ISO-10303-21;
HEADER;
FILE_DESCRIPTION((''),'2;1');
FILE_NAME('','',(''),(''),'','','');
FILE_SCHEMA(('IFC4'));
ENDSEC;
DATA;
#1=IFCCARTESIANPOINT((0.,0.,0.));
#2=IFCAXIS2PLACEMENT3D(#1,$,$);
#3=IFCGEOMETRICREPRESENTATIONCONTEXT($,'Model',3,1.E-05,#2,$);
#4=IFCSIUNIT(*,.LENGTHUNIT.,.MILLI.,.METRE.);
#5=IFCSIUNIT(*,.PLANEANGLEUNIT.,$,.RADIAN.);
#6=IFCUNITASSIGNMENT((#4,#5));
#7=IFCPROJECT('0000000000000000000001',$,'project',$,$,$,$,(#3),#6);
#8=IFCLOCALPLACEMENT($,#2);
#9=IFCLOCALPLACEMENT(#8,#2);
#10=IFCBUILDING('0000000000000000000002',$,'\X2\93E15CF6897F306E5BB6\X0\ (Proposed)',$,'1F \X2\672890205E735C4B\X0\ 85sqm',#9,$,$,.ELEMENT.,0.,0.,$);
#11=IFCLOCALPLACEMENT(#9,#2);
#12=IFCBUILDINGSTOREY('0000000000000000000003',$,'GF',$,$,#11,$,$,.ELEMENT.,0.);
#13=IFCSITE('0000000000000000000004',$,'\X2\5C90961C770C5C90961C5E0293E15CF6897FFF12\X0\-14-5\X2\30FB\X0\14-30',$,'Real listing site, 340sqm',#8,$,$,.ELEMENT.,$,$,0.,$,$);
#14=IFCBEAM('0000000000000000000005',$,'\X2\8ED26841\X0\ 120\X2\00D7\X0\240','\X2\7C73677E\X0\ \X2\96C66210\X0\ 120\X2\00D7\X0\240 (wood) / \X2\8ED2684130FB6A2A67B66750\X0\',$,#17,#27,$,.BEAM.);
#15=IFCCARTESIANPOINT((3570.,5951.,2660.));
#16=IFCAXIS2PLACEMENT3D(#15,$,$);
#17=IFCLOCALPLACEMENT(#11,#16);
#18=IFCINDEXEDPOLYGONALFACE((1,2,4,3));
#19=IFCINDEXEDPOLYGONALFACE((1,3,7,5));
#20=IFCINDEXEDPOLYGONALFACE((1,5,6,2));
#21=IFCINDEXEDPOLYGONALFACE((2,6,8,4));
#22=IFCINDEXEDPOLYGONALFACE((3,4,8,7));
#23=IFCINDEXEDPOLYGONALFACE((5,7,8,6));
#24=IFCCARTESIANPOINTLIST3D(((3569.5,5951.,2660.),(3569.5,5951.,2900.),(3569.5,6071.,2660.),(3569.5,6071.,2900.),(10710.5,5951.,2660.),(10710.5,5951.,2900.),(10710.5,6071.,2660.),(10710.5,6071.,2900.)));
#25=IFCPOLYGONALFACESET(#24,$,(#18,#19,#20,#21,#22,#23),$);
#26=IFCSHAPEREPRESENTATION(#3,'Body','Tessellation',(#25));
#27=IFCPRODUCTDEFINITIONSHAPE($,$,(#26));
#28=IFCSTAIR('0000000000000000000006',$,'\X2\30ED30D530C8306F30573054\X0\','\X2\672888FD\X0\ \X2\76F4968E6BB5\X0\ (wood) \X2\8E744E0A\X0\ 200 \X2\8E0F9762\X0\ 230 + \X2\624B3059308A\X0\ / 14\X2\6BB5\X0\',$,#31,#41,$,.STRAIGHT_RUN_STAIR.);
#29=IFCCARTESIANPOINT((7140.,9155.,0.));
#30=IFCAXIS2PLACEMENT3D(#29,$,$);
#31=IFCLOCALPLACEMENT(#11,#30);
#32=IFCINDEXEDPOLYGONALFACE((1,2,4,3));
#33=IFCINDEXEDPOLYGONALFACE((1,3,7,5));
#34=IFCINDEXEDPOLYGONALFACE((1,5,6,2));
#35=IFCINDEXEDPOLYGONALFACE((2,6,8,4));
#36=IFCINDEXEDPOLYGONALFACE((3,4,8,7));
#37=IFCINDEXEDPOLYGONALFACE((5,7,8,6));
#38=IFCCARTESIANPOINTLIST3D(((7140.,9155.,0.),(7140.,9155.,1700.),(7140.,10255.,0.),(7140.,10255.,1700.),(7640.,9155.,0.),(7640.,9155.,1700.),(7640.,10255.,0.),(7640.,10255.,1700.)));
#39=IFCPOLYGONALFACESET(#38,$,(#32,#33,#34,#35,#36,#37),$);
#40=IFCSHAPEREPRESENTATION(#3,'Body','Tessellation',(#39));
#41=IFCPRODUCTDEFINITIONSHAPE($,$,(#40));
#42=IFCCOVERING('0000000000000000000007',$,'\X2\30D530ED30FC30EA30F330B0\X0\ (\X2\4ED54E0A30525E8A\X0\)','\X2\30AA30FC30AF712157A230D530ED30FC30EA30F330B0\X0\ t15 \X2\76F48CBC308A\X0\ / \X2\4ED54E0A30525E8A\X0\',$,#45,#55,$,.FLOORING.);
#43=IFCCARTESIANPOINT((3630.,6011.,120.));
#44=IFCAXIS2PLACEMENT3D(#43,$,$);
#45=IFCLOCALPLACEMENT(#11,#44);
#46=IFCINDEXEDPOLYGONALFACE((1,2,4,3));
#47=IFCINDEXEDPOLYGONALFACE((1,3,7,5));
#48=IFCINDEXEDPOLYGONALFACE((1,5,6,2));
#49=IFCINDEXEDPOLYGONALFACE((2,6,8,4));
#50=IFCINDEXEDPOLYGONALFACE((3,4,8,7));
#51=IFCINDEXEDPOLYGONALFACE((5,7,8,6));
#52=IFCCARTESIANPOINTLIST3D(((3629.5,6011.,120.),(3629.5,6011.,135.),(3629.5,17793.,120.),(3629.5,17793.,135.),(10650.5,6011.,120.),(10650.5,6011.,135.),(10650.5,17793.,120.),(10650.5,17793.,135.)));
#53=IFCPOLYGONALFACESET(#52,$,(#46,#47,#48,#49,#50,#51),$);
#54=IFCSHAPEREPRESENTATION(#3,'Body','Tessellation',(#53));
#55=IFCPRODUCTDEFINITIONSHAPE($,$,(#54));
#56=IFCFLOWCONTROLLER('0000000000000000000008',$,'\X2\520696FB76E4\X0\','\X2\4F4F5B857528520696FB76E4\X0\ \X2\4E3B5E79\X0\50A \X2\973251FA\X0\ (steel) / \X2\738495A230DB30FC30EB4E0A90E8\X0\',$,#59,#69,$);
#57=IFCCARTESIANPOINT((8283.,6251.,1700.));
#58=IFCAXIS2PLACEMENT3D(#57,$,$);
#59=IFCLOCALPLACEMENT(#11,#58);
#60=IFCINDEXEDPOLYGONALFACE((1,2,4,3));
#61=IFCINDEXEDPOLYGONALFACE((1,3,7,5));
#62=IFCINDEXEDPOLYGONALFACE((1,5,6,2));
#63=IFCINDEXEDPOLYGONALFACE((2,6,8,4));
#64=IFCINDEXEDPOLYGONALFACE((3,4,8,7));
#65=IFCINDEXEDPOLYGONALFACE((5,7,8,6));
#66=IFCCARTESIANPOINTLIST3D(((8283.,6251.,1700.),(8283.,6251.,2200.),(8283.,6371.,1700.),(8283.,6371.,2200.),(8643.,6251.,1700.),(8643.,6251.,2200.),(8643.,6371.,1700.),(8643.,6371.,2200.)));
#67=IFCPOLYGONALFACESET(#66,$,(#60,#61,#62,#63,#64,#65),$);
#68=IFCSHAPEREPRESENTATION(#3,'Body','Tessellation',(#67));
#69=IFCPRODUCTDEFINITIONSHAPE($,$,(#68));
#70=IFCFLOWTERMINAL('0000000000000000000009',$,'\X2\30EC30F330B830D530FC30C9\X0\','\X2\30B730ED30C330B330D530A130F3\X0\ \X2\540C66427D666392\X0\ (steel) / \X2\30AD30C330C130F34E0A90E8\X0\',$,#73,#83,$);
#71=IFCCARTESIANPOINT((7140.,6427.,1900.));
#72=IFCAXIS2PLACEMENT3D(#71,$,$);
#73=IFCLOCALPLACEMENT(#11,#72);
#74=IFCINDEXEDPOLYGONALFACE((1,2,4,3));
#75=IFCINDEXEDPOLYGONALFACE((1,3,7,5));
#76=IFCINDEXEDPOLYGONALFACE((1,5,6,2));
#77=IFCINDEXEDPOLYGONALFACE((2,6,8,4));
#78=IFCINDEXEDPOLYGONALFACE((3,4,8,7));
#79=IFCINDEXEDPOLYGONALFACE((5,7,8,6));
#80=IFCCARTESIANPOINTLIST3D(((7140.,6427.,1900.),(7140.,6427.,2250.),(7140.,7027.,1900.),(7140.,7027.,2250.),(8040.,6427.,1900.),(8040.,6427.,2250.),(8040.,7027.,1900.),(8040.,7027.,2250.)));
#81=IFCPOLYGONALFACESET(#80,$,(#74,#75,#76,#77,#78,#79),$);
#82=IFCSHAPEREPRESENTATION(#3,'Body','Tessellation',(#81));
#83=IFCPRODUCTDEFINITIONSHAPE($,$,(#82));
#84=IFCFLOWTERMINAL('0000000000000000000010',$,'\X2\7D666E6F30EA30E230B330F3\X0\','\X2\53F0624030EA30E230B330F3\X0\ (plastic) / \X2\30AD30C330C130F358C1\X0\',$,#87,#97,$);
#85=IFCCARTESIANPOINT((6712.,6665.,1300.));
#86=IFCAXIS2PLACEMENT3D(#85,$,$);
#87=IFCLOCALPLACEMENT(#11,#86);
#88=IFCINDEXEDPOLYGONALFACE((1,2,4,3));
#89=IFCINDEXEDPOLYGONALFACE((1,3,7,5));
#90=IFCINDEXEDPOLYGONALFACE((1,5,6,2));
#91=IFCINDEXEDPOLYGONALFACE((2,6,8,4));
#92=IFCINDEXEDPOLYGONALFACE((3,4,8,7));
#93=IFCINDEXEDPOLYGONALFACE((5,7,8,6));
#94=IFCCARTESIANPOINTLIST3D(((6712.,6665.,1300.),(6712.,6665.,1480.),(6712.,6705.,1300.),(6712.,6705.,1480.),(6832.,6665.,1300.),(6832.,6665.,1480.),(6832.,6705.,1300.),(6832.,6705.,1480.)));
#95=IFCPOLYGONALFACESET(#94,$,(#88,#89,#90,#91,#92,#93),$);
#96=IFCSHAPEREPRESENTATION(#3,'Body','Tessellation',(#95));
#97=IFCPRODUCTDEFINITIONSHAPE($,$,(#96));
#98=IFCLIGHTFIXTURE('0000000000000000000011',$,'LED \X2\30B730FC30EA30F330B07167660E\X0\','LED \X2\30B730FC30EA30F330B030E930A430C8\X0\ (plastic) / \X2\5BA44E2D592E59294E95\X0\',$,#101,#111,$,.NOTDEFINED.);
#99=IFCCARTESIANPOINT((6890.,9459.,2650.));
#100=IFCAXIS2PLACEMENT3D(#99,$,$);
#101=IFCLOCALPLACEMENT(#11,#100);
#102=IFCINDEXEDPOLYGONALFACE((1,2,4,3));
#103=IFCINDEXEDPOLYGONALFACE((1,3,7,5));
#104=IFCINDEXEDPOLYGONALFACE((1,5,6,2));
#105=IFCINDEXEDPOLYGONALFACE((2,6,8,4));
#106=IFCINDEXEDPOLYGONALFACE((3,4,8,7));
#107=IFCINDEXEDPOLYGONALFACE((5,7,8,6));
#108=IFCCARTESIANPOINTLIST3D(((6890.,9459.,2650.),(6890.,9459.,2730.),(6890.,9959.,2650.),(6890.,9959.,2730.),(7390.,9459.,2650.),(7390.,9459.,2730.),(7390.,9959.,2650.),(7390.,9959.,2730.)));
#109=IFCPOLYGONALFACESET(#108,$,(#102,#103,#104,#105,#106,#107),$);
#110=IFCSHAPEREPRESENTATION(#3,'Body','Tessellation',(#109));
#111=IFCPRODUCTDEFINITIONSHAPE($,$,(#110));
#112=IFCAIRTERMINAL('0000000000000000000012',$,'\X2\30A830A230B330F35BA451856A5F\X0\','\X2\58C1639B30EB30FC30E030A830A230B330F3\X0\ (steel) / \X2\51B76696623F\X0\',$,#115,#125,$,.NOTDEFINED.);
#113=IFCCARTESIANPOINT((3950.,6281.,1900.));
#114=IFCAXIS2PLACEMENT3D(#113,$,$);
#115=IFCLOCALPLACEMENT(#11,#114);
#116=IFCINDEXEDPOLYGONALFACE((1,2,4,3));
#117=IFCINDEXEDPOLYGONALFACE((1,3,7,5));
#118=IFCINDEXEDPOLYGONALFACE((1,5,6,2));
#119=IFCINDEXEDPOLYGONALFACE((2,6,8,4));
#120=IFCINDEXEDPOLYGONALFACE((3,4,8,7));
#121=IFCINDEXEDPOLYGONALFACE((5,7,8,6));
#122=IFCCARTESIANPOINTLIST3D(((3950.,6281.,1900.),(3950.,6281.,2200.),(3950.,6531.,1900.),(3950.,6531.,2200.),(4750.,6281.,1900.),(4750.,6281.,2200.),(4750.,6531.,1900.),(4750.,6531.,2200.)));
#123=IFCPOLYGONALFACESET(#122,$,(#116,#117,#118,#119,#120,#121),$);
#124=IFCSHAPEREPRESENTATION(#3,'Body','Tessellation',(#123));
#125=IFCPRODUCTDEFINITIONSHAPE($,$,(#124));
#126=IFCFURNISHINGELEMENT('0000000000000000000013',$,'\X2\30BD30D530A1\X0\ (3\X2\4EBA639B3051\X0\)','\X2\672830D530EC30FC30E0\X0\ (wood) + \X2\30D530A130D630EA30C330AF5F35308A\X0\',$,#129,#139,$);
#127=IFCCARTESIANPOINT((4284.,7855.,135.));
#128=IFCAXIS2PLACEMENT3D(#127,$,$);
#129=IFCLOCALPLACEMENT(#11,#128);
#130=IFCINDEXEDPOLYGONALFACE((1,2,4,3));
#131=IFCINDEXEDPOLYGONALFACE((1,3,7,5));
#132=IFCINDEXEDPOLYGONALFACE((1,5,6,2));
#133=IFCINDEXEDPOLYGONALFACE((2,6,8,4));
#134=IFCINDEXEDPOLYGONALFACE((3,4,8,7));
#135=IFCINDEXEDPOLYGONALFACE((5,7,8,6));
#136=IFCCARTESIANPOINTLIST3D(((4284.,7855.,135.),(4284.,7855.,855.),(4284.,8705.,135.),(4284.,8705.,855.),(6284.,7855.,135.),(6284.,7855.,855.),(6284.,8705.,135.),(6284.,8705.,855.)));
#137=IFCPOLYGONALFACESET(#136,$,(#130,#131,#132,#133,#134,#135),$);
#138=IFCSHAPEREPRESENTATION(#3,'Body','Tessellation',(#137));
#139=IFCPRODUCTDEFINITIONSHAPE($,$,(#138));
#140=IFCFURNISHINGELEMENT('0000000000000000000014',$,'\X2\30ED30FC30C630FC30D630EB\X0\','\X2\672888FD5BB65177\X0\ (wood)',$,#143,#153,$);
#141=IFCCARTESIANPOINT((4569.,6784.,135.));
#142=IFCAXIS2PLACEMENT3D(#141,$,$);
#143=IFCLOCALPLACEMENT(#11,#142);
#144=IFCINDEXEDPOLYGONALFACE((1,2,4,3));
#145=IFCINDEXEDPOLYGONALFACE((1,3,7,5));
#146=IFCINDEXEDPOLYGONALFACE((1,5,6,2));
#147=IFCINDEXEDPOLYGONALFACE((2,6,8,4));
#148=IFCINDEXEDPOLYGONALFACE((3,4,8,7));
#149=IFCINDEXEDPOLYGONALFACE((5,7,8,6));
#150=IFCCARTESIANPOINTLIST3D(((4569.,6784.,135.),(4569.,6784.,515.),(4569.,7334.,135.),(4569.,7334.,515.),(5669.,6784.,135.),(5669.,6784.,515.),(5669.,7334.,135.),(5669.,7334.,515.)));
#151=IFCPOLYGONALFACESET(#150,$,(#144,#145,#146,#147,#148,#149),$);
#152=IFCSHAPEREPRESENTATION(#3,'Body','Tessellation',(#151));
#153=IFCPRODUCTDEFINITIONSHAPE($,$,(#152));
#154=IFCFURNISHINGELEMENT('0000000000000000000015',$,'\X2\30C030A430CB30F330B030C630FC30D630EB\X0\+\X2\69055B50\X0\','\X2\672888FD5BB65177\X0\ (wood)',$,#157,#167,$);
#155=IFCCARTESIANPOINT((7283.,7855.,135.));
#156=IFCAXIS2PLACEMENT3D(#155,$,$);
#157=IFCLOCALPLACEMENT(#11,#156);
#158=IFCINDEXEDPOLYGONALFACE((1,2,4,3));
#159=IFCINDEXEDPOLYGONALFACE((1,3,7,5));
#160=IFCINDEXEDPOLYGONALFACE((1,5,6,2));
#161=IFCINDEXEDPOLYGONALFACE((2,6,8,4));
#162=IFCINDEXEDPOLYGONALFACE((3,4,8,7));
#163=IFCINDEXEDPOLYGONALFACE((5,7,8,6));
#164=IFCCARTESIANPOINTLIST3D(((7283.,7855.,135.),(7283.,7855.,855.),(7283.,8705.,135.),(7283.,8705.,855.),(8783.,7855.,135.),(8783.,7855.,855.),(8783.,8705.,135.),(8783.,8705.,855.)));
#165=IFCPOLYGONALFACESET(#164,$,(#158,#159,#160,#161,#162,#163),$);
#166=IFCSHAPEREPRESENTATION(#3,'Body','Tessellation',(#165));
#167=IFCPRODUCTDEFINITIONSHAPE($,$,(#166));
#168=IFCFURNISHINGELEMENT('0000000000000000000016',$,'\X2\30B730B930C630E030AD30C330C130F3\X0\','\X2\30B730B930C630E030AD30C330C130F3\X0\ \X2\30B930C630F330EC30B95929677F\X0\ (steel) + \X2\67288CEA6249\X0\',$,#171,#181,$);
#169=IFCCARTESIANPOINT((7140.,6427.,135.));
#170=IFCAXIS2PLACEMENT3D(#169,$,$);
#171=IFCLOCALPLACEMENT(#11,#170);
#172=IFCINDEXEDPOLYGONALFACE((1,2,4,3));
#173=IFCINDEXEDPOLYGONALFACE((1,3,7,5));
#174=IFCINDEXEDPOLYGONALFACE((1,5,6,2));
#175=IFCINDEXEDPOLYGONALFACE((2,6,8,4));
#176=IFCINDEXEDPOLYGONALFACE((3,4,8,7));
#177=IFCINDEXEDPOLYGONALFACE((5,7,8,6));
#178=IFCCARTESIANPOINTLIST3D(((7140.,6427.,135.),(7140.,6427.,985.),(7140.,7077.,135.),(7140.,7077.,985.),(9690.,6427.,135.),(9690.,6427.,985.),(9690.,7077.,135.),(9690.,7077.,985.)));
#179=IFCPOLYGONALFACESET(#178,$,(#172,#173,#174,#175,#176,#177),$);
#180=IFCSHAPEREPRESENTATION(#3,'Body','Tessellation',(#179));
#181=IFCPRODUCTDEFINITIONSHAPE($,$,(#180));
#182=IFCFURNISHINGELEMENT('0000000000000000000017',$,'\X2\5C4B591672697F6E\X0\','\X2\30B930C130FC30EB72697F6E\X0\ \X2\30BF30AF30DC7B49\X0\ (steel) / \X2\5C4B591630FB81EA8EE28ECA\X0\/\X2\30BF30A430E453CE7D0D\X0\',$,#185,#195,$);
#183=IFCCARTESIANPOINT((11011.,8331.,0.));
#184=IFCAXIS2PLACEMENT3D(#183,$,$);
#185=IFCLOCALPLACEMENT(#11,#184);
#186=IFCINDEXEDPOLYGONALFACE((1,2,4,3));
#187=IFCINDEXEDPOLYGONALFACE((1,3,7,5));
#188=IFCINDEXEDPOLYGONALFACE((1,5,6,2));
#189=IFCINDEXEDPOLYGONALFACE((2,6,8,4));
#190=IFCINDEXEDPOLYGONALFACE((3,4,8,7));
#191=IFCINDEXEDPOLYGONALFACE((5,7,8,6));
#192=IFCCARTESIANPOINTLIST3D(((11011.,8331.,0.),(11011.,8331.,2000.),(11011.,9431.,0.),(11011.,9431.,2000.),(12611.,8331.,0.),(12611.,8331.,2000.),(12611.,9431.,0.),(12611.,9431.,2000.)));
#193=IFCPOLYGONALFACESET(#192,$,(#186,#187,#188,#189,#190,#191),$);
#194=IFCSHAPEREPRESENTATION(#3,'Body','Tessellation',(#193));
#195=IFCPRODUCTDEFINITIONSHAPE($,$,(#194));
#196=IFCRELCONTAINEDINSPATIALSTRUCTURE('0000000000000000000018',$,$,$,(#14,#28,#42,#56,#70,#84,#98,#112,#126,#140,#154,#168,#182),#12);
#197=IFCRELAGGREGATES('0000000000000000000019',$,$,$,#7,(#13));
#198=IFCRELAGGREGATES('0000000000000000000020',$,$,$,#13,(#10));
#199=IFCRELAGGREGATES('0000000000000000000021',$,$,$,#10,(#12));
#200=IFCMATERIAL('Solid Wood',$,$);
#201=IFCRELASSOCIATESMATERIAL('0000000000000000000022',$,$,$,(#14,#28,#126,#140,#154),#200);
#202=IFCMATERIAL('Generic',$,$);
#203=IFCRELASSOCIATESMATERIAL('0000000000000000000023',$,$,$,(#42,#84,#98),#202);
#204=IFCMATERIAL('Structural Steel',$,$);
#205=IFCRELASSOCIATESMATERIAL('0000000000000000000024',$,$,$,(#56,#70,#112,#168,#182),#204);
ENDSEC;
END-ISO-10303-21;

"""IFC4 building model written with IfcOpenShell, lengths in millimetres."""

from ifc_helpers import new_model, si_unit, frame, frame_2d, origin, place, context, project, spatial, rectangle, extrude, material, element, save


model = new_model("IFC4")

# Units and contexts
model_context = context("Model", 3, precision=1e-05, world=origin())
ifc_project = project(units=[si_unit("LENGTHUNIT", "METRE", prefix="MILLI"), si_unit("PLANEANGLEUNIT", "RADIAN")], contexts=[model_context])

# Site, building, storey
site_placement = place(None, origin())
site = spatial("IfcSite", under=ifc_project, at=site_placement, Name="岐阜県岐阜市鏡島西２-14-5・14-30", ObjectType="Real listing site, 340sqm", CompositionType="ELEMENT", RefElevation=0.0)
building_placement = place(site_placement, origin())
building = spatial("IfcBuilding", under=site, at=building_placement, Name="鏡島西の家 (Proposed)", ObjectType="1F 木造平屋 85sqm", CompositionType="ELEMENT", ElevationOfRefHeight=0.0, ElevationOfTerrain=0.0)
storey_placement = place(building_placement, origin())
storey = spatial("IfcBuildingStorey", under=building, at=storey_placement, Name="GF", CompositionType="ELEMENT", Elevation=0.0)

# Shared definitions
ifc_material_1 = material(Name="Solid Wood")

# Beam
beam_1_placement = place(storey_placement, frame((3570.0, 5951.0, 2660.0)))
element("IfcBeam", 1, at=beam_1_placement, inside=storey, material=ifc_material_1, Name="軒桁 120×240", Description="米松 集成 120×240 (wood) / 軒桁・横架材", PredefinedType="BEAM", context=model_context, shape_type="SweptSolid", body=[
    extrude(rectangle(XDim=7141.0, YDim=120.0, at=frame_2d((3570.0, 60.0))), frame((3570.0, 5951.0, 2660.0)), (0.0, 0.0, 1.0), 240.0),
])

# Stair
stair_placement = place(storey_placement, frame((7140.0, 9155.0, 0.0)))
element("IfcStair", 2, at=stair_placement, inside=storey, material=ifc_material_1, Name="ロフトはしご", Description="木製 直階段 (wood) 蹴上 200 踏面 230 + 手すり / 14段", PredefinedType="STRAIGHT_RUN_STAIR", context=model_context, shape_type="SweptSolid", body=[
    extrude(rectangle(XDim=500.0, YDim=1100.0, at=frame_2d((250.0, 550.0))), frame((7140.0, 9155.0, 0.0)), (0.0, 0.0, 1.0), 1700.0),
])

# Covering
ifc_material_2 = material(Name="Generic")
covering_placement = place(storey_placement, frame((3630.0, 6011.0, 120.0)))
element("IfcCovering", 3, at=covering_placement, inside=storey, material=ifc_material_2, Name="フローリング (仕上げ床)", Description="オーク無垢フローリング t15 直貼り / 仕上げ床", PredefinedType="FLOORING", context=model_context, shape_type="SweptSolid", body=[
    extrude(rectangle(XDim=7021.0, YDim=11782.0, at=frame_2d((3510.0, 5891.0))), frame((3630.0, 6011.0, 120.0)), (0.0, 0.0, 1.0), 15.0),
])

# Flow controller
ifc_material_3 = material(Name="Structural Steel")
flow_controller_placement = place(storey_placement, frame((8283.0, 6251.0, 1700.0)))
element("IfcFlowController", 4, at=flow_controller_placement, inside=storey, material=ifc_material_3, Name="分電盤", Description="住宅用分電盤 主幹50A 露出 (steel) / 玄関ホール上部", context=model_context, shape_type="SweptSolid", body=[
    extrude(rectangle(XDim=360.0, YDim=120.0, at=frame_2d((180.0, 60.0))), frame((8283.0, 6251.0, 1700.0)), (0.0, 0.0, 1.0), 500.0),
])

# Flow terminals
flow_terminal_1_placement = place(storey_placement, frame((7140.0, 6427.0, 1900.0)))
element("IfcFlowTerminal", 5, at=flow_terminal_1_placement, inside=storey, material=ifc_material_3, Name="レンジフード", Description="シロッコファン 同時給排 (steel) / キッチン上部", context=model_context, shape_type="SweptSolid", body=[
    extrude(rectangle(XDim=900.0, YDim=600.0, at=frame_2d((450.0, 300.0))), frame((7140.0, 6427.0, 1900.0)), (0.0, 0.0, 1.0), 350.0),
])
flow_terminal_2_placement = place(storey_placement, frame((6712.0, 6665.0, 1300.0)))
element("IfcFlowTerminal", 6, at=flow_terminal_2_placement, inside=storey, material=ifc_material_2, Name="給湯リモコン", Description="台所リモコン (plastic) / キッチン壁", context=model_context, shape_type="SweptSolid", body=[
    extrude(rectangle(XDim=120.0, YDim=40.0, at=frame_2d((60.0, 20.0))), frame((6712.0, 6665.0, 1300.0)), (0.0, 0.0, 1.0), 180.0),
])

# Light fixture
light_fixture_placement = place(storey_placement, frame((6890.0, 9459.0, 2650.0)))
element("IfcLightFixture", 7, at=light_fixture_placement, inside=storey, material=ifc_material_2, Name="LED シーリング照明", Description="LED シーリングライト (plastic) / 室中央天井", PredefinedType="NOTDEFINED", context=model_context, shape_type="SweptSolid", body=[
    extrude(rectangle(XDim=500.0, YDim=500.0, at=frame_2d((250.0, 250.0))), frame((6890.0, 9459.0, 2650.0)), (0.0, 0.0, 1.0), 80.0),
])

# Air terminal
air_terminal_placement = place(storey_placement, frame((3950.0, 6281.0, 1900.0)))
element("IfcAirTerminal", 8, at=air_terminal_placement, inside=storey, material=ifc_material_3, Name="エアコン室内機", Description="壁掛ルームエアコン (steel) / 冷暖房", PredefinedType="NOTDEFINED", context=model_context, shape_type="SweptSolid", body=[
    extrude(rectangle(XDim=800.0, YDim=250.0, at=frame_2d((400.0, 125.0))), frame((3950.0, 6281.0, 1900.0)), (0.0, 0.0, 1.0), 300.0),
])

# Furnishing elements
furnishing_1_placement = place(storey_placement, frame((4284.0, 7855.0, 135.0)))
element("IfcFurnishingElement", 9, at=furnishing_1_placement, inside=storey, material=ifc_material_1, Name="ソファ (3人掛け)", Description="木フレーム (wood) + ファブリック張り", context=model_context, shape_type="SweptSolid", body=[
    extrude(rectangle(XDim=2000.0, YDim=850.0, at=frame_2d((1000.0, 425.0))), frame((4284.0, 7855.0, 135.0)), (0.0, 0.0, 1.0), 720.0),
])
furnishing_2_placement = place(storey_placement, frame((4569.0, 6784.0, 135.0)))
element("IfcFurnishingElement", 10, at=furnishing_2_placement, inside=storey, material=ifc_material_1, Name="ローテーブル", Description="木製家具 (wood)", context=model_context, shape_type="SweptSolid", body=[
    extrude(rectangle(XDim=1100.0, YDim=550.0, at=frame_2d((550.0, 275.0))), frame((4569.0, 6784.0, 135.0)), (0.0, 0.0, 1.0), 380.0),
])
furnishing_3_placement = place(storey_placement, frame((7283.0, 7855.0, 135.0)))
element("IfcFurnishingElement", 11, at=furnishing_3_placement, inside=storey, material=ifc_material_1, Name="ダイニングテーブル+椅子", Description="木製家具 (wood)", context=model_context, shape_type="SweptSolid", body=[
    extrude(rectangle(XDim=1500.0, YDim=850.0, at=frame_2d((750.0, 425.0))), frame((7283.0, 7855.0, 135.0)), (0.0, 0.0, 1.0), 720.0),
])
furnishing_4_placement = place(storey_placement, frame((7140.0, 6427.0, 135.0)))
element("IfcFurnishingElement", 12, at=furnishing_4_placement, inside=storey, material=ifc_material_3, Name="システムキッチン", Description="システムキッチン ステンレス天板 (steel) + 木質扉", context=model_context, shape_type="SweptSolid", body=[
    extrude(rectangle(XDim=2550.0, YDim=650.0, at=frame_2d((1275.0, 325.0))), frame((7140.0, 6427.0, 135.0)), (0.0, 0.0, 1.0), 850.0),
])
furnishing_5_placement = place(storey_placement, frame((11011.0, 8331.0, 0.0)))
element("IfcFurnishingElement", 13, at=furnishing_5_placement, inside=storey, material=ifc_material_3, Name="屋外物置", Description="スチール物置 タクボ等 (steel) / 屋外・自転車/タイヤ収納", context=model_context, shape_type="SweptSolid", body=[
    extrude(rectangle(XDim=1600.0, YDim=1100.0, at=frame_2d((800.0, 550.0))), frame((11011.0, 8331.0, 0.0)), (0.0, 0.0, 1.0), 2000.0),
])

save(model, "model.ifc")
